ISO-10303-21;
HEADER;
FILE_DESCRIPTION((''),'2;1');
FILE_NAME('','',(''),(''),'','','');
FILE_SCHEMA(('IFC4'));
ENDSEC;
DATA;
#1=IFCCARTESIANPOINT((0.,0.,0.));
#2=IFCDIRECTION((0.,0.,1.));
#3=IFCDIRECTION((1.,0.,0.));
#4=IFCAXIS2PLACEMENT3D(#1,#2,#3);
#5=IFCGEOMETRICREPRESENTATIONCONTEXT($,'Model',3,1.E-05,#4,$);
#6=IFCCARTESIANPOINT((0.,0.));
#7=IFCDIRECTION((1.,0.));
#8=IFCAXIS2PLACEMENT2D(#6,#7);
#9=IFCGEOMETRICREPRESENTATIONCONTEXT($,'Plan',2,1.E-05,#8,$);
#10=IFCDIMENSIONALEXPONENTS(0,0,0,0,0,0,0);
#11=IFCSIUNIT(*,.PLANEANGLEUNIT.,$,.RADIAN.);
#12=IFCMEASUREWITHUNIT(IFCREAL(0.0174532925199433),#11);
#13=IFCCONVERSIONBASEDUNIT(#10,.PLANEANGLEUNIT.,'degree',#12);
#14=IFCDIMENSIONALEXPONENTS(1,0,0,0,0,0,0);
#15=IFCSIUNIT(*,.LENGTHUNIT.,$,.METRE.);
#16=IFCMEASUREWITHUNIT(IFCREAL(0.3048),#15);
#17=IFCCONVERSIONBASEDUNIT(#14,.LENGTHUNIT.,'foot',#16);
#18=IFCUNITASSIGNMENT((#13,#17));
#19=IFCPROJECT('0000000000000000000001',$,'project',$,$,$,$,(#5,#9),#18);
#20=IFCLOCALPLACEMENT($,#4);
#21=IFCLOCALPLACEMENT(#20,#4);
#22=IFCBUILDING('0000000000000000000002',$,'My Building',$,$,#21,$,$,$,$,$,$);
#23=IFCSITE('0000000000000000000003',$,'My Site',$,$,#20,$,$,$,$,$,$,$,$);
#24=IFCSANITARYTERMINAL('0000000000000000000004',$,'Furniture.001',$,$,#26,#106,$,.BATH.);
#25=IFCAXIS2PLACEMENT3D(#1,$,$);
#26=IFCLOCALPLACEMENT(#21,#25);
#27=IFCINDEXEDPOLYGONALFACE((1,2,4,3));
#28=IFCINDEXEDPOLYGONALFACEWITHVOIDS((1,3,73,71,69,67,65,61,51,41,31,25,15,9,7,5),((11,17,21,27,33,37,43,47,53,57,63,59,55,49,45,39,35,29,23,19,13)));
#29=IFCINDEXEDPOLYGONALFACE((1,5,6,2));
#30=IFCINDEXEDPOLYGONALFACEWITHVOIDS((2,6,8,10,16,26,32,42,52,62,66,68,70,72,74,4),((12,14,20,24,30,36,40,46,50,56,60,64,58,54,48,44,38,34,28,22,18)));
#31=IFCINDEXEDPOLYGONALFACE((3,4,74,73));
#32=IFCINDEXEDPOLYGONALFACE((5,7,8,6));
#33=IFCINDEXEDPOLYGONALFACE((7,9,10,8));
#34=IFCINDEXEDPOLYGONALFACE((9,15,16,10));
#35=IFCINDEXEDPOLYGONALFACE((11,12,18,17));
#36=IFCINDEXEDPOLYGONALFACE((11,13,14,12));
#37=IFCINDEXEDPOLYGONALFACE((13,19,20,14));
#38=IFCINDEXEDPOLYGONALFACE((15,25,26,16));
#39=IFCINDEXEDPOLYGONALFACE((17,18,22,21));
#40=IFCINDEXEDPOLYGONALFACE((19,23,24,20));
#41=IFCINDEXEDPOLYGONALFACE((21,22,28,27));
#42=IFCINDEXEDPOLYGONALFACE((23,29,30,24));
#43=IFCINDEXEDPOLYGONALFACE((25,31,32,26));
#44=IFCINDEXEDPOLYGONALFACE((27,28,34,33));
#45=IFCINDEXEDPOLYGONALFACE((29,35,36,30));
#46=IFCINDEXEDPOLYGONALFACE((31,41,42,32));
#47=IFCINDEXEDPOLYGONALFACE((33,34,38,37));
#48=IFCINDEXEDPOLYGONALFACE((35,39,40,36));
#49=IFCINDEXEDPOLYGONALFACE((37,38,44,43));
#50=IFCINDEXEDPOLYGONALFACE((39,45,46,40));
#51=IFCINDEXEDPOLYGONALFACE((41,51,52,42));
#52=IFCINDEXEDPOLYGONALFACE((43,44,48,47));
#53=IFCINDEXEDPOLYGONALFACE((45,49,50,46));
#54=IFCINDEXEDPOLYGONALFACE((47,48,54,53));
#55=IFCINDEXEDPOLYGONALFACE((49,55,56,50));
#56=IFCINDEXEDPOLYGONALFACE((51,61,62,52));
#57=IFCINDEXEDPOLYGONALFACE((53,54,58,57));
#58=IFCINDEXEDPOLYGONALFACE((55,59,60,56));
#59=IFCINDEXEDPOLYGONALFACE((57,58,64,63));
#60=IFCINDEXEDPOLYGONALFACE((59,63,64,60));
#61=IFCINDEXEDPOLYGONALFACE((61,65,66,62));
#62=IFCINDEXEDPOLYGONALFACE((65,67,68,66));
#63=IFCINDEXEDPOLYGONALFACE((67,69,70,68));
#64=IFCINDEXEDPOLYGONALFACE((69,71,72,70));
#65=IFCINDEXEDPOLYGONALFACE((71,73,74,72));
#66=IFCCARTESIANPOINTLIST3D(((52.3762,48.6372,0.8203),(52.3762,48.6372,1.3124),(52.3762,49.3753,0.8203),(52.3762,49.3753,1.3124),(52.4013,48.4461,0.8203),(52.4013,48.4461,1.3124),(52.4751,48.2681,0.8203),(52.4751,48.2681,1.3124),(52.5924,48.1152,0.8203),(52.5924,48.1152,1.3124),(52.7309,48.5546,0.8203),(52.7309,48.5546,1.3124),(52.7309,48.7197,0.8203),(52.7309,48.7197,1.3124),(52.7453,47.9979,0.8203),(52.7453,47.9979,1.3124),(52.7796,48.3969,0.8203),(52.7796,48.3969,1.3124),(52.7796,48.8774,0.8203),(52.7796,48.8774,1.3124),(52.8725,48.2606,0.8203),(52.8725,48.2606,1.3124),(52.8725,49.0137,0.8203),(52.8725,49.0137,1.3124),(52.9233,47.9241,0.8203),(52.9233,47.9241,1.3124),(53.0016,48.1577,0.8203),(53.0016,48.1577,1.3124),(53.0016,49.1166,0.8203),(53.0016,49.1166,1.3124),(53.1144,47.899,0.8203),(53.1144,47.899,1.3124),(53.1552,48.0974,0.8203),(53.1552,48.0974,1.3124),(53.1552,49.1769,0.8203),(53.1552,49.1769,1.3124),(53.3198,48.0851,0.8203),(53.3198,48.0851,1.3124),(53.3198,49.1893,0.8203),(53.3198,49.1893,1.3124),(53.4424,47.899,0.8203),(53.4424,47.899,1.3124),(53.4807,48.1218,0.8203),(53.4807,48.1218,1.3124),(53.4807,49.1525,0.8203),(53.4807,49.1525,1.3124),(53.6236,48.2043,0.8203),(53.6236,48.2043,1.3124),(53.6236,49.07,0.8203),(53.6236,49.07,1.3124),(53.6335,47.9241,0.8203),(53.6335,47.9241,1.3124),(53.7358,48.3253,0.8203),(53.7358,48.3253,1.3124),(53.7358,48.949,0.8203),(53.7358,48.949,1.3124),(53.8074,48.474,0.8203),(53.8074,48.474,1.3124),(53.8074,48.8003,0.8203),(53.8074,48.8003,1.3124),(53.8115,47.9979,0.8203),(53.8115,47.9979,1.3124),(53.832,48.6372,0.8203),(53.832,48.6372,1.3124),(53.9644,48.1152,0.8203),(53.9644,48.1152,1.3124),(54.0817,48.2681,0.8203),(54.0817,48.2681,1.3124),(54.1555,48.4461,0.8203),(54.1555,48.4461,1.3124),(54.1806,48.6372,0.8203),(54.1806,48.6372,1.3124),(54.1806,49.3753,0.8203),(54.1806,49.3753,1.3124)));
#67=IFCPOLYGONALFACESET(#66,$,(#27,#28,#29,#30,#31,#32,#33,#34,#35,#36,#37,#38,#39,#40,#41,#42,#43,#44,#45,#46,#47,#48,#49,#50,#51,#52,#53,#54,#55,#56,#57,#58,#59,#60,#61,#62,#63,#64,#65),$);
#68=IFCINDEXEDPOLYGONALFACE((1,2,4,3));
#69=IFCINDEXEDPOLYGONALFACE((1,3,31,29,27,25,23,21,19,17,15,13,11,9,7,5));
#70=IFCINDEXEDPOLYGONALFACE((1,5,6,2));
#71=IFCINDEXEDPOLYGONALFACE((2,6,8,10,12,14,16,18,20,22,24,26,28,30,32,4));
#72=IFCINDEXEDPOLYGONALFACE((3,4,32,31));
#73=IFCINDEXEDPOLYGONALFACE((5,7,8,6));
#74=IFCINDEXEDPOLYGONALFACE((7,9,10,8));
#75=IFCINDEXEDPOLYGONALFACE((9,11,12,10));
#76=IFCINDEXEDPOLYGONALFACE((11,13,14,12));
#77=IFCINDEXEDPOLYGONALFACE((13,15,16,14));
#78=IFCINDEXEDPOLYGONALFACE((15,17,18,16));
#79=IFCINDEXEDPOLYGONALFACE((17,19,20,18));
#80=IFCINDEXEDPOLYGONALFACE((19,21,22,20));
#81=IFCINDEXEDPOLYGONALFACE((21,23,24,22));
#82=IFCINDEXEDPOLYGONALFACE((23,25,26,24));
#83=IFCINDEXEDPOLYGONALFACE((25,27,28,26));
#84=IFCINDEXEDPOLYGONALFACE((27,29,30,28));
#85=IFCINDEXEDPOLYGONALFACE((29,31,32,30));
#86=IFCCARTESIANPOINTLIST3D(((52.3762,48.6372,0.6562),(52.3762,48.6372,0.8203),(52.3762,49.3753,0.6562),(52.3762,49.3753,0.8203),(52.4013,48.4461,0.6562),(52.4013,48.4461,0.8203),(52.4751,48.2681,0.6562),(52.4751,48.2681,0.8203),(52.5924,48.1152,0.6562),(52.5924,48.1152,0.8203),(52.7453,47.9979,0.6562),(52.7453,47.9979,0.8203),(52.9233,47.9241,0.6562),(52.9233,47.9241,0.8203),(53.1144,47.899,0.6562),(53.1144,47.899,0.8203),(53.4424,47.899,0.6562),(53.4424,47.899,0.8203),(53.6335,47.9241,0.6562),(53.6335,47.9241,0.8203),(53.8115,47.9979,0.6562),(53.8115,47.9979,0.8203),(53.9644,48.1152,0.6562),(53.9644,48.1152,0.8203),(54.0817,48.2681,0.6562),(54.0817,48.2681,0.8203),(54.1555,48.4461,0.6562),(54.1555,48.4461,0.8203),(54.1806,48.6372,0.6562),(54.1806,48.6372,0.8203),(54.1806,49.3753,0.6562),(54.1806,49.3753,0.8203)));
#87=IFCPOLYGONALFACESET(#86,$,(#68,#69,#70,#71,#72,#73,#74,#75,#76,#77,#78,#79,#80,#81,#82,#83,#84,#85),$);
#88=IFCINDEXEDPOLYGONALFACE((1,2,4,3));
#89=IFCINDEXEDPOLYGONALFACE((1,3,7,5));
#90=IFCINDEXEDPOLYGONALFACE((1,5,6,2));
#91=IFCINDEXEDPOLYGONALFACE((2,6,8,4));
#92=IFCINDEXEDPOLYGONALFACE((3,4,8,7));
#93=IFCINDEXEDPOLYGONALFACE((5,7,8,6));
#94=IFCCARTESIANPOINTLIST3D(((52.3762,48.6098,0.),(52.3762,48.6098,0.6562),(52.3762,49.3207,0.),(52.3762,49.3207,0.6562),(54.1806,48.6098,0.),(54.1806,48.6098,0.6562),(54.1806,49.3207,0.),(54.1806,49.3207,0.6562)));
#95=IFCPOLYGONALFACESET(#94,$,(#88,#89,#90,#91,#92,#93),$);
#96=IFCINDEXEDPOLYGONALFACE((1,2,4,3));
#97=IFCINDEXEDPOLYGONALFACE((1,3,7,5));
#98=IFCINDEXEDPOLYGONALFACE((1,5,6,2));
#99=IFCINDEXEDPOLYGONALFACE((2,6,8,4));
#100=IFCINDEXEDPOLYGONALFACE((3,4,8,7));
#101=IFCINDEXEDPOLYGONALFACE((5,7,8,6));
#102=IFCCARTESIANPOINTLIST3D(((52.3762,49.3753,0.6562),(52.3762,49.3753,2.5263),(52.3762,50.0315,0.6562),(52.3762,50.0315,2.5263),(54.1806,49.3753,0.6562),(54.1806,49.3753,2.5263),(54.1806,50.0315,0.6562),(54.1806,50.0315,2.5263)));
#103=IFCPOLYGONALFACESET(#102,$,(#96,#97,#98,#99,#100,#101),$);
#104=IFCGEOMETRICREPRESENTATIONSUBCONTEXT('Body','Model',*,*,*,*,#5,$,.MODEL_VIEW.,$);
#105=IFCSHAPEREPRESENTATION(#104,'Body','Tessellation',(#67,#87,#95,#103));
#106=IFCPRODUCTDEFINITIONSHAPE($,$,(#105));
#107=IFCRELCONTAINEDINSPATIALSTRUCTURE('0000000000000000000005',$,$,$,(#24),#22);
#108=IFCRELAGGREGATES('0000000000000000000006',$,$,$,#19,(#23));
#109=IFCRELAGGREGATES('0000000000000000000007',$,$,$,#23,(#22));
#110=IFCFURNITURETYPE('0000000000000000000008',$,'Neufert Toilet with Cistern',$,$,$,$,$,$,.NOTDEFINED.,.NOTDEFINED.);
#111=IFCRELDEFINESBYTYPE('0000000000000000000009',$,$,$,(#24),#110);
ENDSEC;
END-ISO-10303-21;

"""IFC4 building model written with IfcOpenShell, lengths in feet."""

from ifc_helpers import new_model, entity, si_unit, converted_unit, frame, frame_2d, origin_with_axes, origin_2d_with_axis, place, context, subcontext, project, spatial, line, arc, indexed_curve, circle_curve, outline, extrude, shape, source, transform, mapped, type_object, type_shapes, element, save


model = new_model("IFC4")

# Units and contexts
model_context = context("Model", 3, precision=1e-05, world=origin_with_axes())
plan_context = context("Plan", 2, precision=1e-05, world=origin_2d_with_axis())
body_context_1 = subcontext(model_context, "Body", "Model", "MODEL_VIEW")
body_context_2 = subcontext(plan_context, "Body", "Plan", "PLAN_VIEW")
ifc_project = project(units=[converted_unit("PLANEANGLEUNIT", "degree", entity("IfcReal", 0.0174532925199433), si_unit("PLANEANGLEUNIT", "RADIAN"), dimensions=[0, 0, 0, 0, 0, 0, 0]), converted_unit("LENGTHUNIT", "foot", entity("IfcReal", 0.3048), si_unit("LENGTHUNIT", "METRE"), dimensions=[1, 0, 0, 0, 0, 0, 0])], contexts=[model_context, plan_context])

# Site, building
site_placement = place(None, origin_with_axes())
site = spatial("IfcSite", under=ifc_project, at=site_placement, Name="My Site")
building_placement = place(site_placement, origin_with_axes())
building = spatial("IfcBuilding", under=site, at=building_placement, Name="My Building")

# Sanitary terminal
furniture_type_1 = type_object("IfcFurnitureType", Name="Neufert Toilet with Cistern", AssemblyPlace="NOTDEFINED", PredefinedType="NOTDEFINED")
shared_shape_1 = source(origin_with_axes(), body_context_1, "Body", "SweptSolid", [
    extrude(outline(indexed_curve([(-0.9022, -0.6562), (0.9022, -0.6562), (0.9022, -1.3944), (0.686, -1.9163), (0.164, -2.1325), (-0.164, -2.1325), (-0.686, -1.9163), (-0.9022, -1.3944)], segments=[line(1, 2), line(2, 3), arc(3, 4, 5), line(5, 6), arc(6, 7, 8), line(1, 8)]), holes=[circle_curve(frame_2d((0.0, -1.3944)), 0.5536)]), frame((0.0, 0.0, 0.8202), z_axis=(0.0, 0.0, 1.0), x_axis=(1.0, 0.0, 0.0)), (0.0, 0.0, 1.0), 0.4921),
    extrude(outline(indexed_curve([(-0.9022, -0.6562), (0.9022, -0.6562), (0.9022, -1.3944), (0.686, -1.9163), (0.164, -2.1325), (-0.164, -2.1325), (-0.686, -1.9163), (-0.9022, -1.3944)], segments=[line(1, 2), line(2, 3), arc(3, 4, 5), line(5, 6), arc(6, 7, 8), line(1, 8)])), frame((0.0, 0.0, 0.6562), z_axis=(0.0, 0.0, 1.0), x_axis=(1.0, 0.0, 0.0)), (0.0, 0.0, 1.0), 0.164),
    extrude(outline(indexed_curve([(-0.9022, -0.7108), (0.9022, -0.7108), (0.9022, -1.4217), (-0.9022, -1.4217)], segments=[line(1, 2), line(2, 3), line(3, 4), line(4, 1)])), origin_with_axes(), (0.0, 0.0, 1.0), 0.6562),
    extrude(outline(indexed_curve([(-0.9022, 0.0), (0.9022, 0.0), (0.9022, -0.6562), (-0.9022, -0.6562)], segments=[line(1, 2), line(2, 3), line(3, 4), line(4, 1)])), frame((0.0, 0.0, 0.6562), z_axis=(0.0, 0.0, 1.0), x_axis=(1.0, 0.0, 0.0)), (0.0, 0.0, 1.0), 1.8701),
])
shared_shape_2 = source(origin_with_axes(), body_context_2, "Body", "Curve2D", [
    entity("IfcIndexedPolyCurve", entity("IfcCartesianPointList2D", [[-0.9022, 0.0], [0.9022, 0.0], [0.9022, -0.6562], [-0.9022, -0.6562]]), [entity("IfcLineIndex", [1, 2]), entity("IfcLineIndex", [2, 3]), entity("IfcLineIndex", [3, 4]), entity("IfcLineIndex", [4, 1])]),
    entity("IfcIndexedPolyCurve", entity("IfcCartesianPointList2D", [[0.5413, -0.6562], [0.6316, -1.0991]]), [entity("IfcLineIndex", [1, 2])]),
    entity("IfcTrimmedCurve", entity("IfcEllipse", entity("IfcAxis2Placement2D", entity("IfcCartesianPoint", [0.0, -1.0991]), entity("IfcDirection", [1.0, 0.0])), 0.6316, 1.0335), [entity("IfcCartesianPoint", [-0.6316, -1.0991])], [entity("IfcCartesianPoint", [0.6316, -1.0991])], True, "CARTESIAN"),
    entity("IfcIndexedPolyCurve", entity("IfcCartesianPointList2D", [[-0.5413, -0.6562], [-0.6316, -1.0991]]), [entity("IfcLineIndex", [1, 2])]),
    entity("IfcEllipse", entity("IfcAxis2Placement2D", entity("IfcCartesianPoint", [0.0, -1.4829]), entity("IfcDirection", [1.0, 0.0])), 0.4306, 0.5167),
    entity("IfcIndexedPolyCurve", entity("IfcCartesianPointList2D", [[-0.1128, -1.4829], [-0.1128, -1.4091], [0.1128, -1.4091], [0.1128, -1.4829]]), [entity("IfcLineIndex", [1, 2]), entity("IfcLineIndex", [2, 3]), entity("IfcLineIndex", [3, 4])]),
    entity("IfcTrimmedCurve", entity("IfcEllipse", entity("IfcAxis2Placement2D", entity("IfcCartesianPoint", [0.0, -1.4829]), entity("IfcDirection", [1.0, 0.0])), 0.1128, 0.0738), [entity("IfcCartesianPoint", [-0.1128, -1.4829])], [entity("IfcCartesianPoint", [0.1128, -1.4829])], True, "CARTESIAN"),
])
type_shapes(furniture_type_1, [shared_shape_1, shared_shape_2])
sanitary_terminal_1_placement = place(building_placement, frame((53.2784, 50.0315, 0.0), z_axis=(0.0, 0.0, 1.0), x_axis=(1.0, 0.0, 0.0)))
element("IfcSanitaryTerminal", 1, at=sanitary_terminal_1_placement, inside=building, type_object=furniture_type_1, Name="Furniture.001", PredefinedType="BATH", shapes=[
    shape(body_context_1, "Body", "MappedRepresentation", [mapped(shared_shape_1, transform((0.0, 0.0, 0.0), x_axis=(1.0, 0.0, 0.0), y_axis=(0.0, 1.0, 0.0), z_axis=(0.0, 0.0, 1.0), scale=1.0))]),
    shape(body_context_2, "Body", "MappedRepresentation", [mapped(shared_shape_2, transform((0.0, 0.0, 0.0), x_axis=(1.0, 0.0, 0.0), y_axis=(0.0, 1.0, 0.0), z_axis=(0.0, 0.0, 1.0), scale=1.0))]),
])

save(model, "model.ifc")
